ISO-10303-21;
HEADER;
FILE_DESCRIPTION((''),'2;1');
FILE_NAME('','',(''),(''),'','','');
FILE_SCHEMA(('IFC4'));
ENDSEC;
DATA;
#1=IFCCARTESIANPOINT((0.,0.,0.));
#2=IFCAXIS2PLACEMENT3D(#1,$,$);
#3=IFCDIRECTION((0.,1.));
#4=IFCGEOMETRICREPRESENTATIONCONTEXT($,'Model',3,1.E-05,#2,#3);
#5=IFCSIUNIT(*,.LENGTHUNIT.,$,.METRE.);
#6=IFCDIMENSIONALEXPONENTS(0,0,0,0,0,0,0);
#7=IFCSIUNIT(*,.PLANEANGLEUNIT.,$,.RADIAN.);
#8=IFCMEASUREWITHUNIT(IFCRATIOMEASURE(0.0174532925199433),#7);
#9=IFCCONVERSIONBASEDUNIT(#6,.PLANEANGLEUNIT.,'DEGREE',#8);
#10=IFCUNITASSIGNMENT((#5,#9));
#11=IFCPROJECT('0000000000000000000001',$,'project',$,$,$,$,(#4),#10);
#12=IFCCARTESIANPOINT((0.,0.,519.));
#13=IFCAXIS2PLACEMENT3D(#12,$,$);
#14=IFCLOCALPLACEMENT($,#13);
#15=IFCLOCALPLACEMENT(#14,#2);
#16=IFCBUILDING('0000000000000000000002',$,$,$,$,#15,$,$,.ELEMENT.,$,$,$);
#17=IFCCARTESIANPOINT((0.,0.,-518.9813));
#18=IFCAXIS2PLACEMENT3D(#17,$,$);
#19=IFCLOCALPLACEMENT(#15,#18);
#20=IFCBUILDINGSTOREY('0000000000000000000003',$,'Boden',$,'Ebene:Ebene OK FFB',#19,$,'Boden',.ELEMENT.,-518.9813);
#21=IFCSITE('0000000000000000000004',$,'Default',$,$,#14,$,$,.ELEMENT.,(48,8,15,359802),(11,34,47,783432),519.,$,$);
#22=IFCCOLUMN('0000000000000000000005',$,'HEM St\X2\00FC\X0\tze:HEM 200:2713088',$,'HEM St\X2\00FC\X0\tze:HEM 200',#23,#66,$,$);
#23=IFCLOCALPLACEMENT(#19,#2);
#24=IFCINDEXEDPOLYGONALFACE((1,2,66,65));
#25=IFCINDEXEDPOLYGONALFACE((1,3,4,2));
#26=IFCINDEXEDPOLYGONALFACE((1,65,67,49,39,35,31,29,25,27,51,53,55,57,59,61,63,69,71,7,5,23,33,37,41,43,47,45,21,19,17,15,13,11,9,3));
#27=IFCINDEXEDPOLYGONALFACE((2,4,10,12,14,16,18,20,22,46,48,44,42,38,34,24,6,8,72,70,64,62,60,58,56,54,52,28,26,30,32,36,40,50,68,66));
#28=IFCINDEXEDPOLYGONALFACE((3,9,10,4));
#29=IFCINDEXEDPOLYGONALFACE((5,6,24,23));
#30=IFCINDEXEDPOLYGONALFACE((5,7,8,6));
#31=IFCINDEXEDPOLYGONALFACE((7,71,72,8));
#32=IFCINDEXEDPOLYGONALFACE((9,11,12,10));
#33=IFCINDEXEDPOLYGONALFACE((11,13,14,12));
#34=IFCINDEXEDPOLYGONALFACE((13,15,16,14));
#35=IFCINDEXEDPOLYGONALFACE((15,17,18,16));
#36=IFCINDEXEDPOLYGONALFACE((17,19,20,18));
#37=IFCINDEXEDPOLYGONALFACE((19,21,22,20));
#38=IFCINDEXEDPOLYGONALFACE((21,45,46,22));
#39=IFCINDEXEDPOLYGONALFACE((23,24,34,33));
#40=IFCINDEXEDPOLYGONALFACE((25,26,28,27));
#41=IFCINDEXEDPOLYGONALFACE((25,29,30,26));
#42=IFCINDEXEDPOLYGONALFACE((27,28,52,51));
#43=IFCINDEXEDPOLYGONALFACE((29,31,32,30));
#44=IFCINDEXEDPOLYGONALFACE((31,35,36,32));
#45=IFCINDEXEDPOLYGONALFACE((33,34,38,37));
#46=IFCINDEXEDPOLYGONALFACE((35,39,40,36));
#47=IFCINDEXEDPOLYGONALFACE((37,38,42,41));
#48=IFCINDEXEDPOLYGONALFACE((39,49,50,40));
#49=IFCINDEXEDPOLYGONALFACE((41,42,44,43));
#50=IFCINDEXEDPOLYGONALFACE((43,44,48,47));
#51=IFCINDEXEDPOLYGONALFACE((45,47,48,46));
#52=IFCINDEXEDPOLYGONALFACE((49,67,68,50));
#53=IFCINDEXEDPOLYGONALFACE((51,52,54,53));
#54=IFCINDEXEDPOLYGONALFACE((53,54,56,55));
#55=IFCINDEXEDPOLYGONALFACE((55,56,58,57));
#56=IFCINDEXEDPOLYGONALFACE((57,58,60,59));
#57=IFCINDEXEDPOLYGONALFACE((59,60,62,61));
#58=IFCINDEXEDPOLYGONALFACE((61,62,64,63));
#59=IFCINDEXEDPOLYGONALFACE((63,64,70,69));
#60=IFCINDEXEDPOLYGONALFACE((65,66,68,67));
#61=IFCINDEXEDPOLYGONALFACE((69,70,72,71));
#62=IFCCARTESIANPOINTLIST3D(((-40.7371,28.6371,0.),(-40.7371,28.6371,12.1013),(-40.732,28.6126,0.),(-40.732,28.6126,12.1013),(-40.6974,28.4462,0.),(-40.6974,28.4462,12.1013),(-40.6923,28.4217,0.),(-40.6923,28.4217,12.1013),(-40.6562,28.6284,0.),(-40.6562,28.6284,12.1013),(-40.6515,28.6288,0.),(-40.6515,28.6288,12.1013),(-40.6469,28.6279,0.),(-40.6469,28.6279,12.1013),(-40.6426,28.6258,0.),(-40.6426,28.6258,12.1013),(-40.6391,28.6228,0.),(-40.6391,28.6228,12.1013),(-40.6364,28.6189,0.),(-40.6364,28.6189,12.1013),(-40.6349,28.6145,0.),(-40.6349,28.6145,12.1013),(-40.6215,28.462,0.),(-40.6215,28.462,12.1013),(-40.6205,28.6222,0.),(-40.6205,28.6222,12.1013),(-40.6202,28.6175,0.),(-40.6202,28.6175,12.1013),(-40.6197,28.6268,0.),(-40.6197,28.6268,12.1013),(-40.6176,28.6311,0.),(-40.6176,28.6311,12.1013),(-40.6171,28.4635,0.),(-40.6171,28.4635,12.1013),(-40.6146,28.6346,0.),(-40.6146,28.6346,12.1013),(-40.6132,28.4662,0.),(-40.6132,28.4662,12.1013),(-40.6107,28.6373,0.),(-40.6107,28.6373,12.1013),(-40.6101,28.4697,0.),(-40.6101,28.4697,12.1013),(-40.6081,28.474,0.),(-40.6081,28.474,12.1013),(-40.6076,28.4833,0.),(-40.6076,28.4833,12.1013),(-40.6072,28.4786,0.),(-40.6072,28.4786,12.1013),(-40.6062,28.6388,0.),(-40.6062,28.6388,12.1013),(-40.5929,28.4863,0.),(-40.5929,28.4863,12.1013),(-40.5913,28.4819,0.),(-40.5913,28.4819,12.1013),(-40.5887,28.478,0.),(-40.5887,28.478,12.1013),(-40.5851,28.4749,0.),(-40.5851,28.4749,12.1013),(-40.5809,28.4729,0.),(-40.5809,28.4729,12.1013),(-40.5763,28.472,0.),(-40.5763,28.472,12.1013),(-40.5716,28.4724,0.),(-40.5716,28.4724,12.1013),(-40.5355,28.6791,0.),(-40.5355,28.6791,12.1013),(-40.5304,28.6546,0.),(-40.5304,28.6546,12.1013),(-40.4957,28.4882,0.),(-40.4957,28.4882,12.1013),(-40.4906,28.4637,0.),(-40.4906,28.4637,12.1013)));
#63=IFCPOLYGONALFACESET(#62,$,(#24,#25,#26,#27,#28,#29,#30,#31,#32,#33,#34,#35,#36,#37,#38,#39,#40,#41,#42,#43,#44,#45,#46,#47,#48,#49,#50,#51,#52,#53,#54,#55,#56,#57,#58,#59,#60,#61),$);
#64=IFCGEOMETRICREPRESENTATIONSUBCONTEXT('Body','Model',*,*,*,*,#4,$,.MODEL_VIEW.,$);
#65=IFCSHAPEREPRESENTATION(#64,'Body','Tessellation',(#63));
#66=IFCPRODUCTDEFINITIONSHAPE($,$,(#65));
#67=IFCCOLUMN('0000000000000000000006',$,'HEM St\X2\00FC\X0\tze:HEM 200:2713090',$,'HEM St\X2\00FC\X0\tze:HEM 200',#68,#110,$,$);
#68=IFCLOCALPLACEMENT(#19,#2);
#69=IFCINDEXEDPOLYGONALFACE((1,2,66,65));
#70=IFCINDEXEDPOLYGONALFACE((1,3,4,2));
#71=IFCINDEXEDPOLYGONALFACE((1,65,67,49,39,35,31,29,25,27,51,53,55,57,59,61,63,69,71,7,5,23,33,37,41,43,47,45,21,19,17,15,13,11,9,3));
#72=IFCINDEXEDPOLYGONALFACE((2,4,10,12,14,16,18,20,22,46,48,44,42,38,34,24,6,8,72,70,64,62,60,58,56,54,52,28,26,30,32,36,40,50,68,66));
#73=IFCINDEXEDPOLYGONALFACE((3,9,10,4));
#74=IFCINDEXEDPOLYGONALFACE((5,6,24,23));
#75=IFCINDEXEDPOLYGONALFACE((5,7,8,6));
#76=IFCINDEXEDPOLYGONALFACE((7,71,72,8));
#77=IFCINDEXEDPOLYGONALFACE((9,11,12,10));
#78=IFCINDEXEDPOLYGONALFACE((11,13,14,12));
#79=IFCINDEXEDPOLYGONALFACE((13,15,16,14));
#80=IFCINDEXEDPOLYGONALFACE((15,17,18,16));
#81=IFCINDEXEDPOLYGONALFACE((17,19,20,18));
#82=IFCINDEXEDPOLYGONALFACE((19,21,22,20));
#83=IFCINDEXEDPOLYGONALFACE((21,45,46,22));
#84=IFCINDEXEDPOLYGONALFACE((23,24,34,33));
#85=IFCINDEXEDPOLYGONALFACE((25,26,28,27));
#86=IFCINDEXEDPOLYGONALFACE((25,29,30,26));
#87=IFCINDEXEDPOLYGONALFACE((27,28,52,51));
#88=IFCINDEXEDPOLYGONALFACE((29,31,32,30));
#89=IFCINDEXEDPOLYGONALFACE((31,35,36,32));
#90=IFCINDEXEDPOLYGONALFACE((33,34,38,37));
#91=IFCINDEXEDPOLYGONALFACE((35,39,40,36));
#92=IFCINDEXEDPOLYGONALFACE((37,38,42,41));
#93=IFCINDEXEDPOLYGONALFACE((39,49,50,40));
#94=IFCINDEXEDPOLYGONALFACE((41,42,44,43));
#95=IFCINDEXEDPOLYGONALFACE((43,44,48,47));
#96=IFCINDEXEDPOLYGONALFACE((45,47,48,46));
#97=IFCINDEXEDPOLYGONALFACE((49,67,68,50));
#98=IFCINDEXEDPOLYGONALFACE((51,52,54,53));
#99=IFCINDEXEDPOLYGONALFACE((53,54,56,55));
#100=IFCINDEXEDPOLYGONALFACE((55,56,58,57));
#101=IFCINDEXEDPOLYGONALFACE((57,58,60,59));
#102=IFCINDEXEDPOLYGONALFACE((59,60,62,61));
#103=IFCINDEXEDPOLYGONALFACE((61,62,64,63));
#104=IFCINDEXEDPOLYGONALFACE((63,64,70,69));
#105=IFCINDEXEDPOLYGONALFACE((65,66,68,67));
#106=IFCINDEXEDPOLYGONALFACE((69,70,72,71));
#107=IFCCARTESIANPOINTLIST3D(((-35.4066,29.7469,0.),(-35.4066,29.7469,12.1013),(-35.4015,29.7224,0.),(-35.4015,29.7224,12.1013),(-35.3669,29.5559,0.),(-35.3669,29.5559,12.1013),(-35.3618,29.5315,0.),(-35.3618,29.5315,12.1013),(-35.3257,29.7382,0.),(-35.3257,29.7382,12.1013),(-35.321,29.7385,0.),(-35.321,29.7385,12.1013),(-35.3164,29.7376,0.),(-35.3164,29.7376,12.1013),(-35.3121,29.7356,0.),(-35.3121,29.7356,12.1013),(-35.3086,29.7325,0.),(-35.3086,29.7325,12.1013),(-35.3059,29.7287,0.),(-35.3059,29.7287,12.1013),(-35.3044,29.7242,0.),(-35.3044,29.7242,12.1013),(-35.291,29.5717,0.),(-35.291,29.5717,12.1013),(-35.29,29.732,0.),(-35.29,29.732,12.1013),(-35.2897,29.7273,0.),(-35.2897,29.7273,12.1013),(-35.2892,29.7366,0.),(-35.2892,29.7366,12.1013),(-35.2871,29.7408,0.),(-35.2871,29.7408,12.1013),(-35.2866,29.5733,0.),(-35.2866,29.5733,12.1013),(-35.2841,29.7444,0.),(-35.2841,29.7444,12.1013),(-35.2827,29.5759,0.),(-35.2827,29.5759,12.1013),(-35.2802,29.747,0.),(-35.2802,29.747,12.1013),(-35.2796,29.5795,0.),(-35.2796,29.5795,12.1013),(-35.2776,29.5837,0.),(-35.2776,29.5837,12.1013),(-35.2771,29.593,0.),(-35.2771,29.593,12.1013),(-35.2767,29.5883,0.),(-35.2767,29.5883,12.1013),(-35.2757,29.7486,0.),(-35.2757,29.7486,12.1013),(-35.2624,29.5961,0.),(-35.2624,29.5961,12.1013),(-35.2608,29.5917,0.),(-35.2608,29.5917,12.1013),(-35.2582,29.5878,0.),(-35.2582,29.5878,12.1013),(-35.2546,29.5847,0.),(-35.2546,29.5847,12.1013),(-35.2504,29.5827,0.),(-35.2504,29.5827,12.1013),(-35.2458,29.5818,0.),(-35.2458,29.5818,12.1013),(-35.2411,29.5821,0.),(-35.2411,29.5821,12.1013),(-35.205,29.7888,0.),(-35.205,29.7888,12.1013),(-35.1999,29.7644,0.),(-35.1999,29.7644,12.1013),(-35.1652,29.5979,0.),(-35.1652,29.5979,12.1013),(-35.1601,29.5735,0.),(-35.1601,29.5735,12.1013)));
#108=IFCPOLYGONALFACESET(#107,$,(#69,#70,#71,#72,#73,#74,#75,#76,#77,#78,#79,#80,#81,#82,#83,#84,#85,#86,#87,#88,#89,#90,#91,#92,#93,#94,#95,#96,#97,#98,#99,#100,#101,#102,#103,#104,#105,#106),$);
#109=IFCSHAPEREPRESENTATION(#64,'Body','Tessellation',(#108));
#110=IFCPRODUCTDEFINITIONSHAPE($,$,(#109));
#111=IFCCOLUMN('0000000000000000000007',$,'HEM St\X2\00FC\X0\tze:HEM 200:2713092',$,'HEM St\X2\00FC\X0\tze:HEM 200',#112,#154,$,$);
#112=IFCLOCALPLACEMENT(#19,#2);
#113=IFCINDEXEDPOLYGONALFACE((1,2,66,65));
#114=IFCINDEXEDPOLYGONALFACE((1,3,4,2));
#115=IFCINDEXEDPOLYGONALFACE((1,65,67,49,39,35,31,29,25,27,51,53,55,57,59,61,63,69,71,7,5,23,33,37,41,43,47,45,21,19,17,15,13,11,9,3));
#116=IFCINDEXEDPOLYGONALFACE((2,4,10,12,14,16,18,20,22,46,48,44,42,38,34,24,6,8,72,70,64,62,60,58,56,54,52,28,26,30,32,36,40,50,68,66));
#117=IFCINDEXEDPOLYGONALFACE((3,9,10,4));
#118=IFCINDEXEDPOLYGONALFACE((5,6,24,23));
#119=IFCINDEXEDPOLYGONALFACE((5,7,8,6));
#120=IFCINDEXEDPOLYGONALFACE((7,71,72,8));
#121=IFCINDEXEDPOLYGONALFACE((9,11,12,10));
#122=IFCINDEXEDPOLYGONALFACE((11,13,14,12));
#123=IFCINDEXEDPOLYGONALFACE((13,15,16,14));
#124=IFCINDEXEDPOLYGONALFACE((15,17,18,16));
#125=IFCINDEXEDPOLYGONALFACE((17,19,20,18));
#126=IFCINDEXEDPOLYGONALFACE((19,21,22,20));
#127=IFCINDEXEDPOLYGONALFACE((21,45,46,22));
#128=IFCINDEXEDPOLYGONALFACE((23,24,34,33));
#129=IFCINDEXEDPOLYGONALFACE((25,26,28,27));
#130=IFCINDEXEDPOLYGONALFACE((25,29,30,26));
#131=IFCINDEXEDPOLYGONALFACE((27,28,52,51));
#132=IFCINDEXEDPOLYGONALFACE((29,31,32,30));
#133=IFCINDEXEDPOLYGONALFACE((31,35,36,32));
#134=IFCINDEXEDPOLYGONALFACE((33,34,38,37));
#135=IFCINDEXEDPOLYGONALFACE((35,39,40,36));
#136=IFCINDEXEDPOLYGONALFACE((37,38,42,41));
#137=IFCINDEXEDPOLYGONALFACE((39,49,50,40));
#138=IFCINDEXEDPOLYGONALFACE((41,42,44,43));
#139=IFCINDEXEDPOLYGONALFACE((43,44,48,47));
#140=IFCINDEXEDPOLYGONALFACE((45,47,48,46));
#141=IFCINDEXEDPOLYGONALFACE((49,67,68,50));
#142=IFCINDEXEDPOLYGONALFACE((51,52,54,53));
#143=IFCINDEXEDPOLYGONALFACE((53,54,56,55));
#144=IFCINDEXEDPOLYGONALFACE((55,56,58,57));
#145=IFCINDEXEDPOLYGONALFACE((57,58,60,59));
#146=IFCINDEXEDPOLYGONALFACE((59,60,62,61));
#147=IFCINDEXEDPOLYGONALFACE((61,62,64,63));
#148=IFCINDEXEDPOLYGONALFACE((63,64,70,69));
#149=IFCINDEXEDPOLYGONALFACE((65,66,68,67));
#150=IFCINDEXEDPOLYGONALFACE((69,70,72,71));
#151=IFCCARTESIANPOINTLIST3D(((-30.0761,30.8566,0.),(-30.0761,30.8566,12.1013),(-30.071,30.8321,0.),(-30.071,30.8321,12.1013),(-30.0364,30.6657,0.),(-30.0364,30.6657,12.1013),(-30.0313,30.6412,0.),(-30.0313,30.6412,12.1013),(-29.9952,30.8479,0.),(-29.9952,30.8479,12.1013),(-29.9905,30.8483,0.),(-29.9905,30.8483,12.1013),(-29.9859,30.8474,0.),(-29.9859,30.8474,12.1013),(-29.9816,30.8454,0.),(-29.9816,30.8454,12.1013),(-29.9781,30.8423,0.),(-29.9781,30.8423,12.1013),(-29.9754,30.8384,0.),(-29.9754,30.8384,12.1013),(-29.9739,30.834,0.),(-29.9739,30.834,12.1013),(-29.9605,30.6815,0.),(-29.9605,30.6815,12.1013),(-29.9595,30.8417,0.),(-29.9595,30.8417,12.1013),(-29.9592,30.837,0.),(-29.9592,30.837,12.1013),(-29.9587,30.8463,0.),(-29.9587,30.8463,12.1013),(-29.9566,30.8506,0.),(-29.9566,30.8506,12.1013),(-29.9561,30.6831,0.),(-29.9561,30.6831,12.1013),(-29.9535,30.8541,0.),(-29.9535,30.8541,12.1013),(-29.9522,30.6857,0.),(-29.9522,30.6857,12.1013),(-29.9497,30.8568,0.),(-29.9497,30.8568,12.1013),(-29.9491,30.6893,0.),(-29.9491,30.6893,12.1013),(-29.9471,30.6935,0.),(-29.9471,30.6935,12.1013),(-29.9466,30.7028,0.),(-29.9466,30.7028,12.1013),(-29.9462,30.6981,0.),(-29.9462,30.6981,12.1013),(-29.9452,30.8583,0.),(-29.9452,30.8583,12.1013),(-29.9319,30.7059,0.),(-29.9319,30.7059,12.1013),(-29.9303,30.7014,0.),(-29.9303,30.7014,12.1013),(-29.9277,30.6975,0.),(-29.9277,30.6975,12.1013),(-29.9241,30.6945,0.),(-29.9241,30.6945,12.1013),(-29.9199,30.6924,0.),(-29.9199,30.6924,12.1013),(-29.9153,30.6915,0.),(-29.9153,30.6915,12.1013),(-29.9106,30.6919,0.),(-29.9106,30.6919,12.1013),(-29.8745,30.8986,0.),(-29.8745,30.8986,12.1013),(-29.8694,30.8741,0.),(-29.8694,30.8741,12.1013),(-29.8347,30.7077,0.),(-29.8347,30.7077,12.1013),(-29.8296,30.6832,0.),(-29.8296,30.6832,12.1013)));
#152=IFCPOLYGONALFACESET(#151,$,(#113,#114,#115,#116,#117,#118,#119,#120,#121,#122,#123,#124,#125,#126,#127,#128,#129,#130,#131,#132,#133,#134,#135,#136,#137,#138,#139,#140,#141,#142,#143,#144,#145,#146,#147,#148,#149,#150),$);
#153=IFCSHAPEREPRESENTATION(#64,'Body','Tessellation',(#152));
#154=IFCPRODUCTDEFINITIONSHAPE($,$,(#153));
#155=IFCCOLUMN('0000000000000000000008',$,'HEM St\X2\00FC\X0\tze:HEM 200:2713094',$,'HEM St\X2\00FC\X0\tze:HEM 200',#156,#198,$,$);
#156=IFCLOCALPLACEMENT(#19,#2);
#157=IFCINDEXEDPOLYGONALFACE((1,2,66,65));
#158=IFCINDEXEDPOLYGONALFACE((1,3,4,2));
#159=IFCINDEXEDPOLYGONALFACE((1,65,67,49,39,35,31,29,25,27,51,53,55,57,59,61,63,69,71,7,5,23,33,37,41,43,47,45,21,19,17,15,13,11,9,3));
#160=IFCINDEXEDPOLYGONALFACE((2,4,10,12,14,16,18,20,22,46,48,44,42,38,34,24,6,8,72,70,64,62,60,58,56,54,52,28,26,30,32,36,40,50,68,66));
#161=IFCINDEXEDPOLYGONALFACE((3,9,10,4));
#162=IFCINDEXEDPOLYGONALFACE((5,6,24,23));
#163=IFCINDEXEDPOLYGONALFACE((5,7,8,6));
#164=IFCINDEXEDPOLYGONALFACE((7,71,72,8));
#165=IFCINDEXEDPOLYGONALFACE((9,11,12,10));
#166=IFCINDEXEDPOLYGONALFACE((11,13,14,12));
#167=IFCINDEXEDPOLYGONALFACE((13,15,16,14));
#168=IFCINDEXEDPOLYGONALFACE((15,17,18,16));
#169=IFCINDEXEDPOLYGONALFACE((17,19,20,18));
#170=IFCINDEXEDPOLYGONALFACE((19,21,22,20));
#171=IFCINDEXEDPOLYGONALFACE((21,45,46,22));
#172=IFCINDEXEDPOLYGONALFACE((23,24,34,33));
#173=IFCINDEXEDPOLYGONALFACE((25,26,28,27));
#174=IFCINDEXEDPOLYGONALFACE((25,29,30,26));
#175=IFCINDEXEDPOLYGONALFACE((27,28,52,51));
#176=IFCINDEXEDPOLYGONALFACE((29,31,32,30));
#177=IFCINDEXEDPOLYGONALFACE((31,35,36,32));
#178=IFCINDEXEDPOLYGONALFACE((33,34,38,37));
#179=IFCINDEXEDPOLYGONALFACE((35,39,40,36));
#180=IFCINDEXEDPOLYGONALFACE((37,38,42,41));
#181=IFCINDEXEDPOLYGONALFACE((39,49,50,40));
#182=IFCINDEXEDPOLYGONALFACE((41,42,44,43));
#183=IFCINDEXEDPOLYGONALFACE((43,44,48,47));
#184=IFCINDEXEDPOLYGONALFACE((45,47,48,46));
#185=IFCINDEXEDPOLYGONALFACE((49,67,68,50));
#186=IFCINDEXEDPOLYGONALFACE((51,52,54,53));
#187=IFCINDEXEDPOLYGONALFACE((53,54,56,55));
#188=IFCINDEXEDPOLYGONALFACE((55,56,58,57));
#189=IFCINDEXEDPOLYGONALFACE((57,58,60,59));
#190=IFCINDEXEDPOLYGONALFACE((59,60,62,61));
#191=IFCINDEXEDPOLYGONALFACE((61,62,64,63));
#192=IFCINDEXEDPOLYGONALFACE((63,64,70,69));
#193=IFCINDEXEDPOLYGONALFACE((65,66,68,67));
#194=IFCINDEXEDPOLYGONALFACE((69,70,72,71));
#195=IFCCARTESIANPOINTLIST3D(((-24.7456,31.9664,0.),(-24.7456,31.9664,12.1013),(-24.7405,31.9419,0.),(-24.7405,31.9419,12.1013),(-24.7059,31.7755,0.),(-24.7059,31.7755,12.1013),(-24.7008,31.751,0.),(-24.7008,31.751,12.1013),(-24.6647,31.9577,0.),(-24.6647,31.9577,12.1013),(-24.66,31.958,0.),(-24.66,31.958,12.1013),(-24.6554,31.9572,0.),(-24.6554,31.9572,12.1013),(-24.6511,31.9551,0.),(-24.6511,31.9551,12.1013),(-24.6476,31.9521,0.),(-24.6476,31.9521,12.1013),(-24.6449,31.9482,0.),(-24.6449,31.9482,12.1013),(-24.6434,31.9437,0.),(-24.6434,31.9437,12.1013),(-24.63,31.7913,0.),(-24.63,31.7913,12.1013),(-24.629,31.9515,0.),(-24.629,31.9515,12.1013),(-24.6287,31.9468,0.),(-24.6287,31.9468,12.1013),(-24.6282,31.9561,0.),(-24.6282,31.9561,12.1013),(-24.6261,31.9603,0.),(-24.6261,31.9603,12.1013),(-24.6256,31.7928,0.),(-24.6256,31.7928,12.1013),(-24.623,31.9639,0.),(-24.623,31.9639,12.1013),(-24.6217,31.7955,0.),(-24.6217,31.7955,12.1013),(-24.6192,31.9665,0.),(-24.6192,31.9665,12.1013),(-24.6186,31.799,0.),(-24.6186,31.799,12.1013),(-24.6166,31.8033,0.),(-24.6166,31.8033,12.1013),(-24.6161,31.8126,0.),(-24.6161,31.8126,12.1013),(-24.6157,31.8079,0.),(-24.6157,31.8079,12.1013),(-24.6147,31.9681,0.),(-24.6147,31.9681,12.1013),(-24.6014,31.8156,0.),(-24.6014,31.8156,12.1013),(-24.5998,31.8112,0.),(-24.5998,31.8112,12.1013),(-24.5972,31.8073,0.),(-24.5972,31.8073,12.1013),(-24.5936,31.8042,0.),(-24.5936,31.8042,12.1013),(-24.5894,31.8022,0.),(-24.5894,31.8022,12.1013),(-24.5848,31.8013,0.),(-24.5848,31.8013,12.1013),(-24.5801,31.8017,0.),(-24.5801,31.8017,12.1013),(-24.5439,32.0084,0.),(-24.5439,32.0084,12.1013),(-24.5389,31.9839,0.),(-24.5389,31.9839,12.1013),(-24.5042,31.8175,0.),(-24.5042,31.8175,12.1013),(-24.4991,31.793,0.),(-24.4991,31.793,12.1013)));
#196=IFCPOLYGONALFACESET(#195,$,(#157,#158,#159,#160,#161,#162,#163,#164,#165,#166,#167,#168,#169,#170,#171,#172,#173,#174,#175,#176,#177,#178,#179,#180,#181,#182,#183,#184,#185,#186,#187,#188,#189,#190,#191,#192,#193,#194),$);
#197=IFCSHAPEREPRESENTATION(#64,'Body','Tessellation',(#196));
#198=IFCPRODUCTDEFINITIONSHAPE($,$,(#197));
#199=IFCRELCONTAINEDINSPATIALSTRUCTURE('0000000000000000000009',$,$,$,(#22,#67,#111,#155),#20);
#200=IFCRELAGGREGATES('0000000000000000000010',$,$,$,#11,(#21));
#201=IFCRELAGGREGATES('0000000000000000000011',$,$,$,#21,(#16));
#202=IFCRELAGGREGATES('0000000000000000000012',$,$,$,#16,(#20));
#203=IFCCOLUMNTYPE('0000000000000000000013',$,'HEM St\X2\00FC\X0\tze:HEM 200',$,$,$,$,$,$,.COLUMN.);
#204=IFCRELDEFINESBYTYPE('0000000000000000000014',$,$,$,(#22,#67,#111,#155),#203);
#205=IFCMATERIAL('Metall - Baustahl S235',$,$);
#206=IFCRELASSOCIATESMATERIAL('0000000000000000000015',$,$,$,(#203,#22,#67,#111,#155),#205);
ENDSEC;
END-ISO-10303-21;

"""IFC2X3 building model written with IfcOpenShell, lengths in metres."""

from ifc_helpers import new_model, entity, si_unit, converted_unit, direction, frame, frame_2d, origin, place, context, subcontext, project, spatial, polyline, circle_curve, parameter, trimmed, segment, composite_curve, outline, extrude, source, transform, mapped, material, type_object, type_shapes, element, save


model = new_model("IFC2X3")

# Units and contexts
model_context = context("Model", 3, precision=1e-05, world=origin(), true_north=direction((0.0, 1.0)))
body_context = subcontext(model_context, "Body", "Model", "MODEL_VIEW")
ifc_project = project(units=[si_unit("LENGTHUNIT", "METRE"), converted_unit("PLANEANGLEUNIT", "DEGREE", entity("IfcRatioMeasure", 0.0174532925199433), si_unit("PLANEANGLEUNIT", "RADIAN"), dimensions=[0, 0, 0, 0, 0, 0, 0])], contexts=[model_context])

# Site, building, storey
site_placement = place(None, frame((0.0, 0.0, 519.0)))
site = spatial("IfcSite", under=ifc_project, at=site_placement, Name="Default", CompositionType="ELEMENT", RefLatitude=(48, 8, 15, 359802), RefLongitude=(11, 34, 47, 783432), RefElevation=519.0)
building_placement = place(site_placement, origin())
building = spatial("IfcBuilding", under=site, at=building_placement, CompositionType="ELEMENT")
storey_placement = place(building_placement, frame((0.0, 0.0, -518.9813)))
storey = spatial("IfcBuildingStorey", under=building, at=storey_placement, Name="Boden", ObjectType="Ebene:Ebene OK FFB", LongName="Boden", CompositionType="ELEMENT", Elevation=-518.9813)

# Columns
ifc_material = material(Name="Metall - Baustahl S235")
column_type_1 = type_object("IfcColumnType", Name="HEM Stütze:HEM 200", PredefinedType="COLUMN", material=ifc_material)
shared_shape_1 = source(origin(), body_context, "Body", "SweptSolid", [
    extrude(outline(composite_curve([segment(polyline([(0.085, -0.103), (0.11, -0.103)]), True, "CONTINUOUS"), segment(polyline([(0.11, -0.103), (0.11, 0.103)]), True, "CONTINUOUS"), segment(polyline([(0.11, 0.103), (0.085, 0.103)]), True, "CONTINUOUS"), segment(polyline([(0.085, 0.103), (0.085, 0.0255)]), True, "CONTINUOUS"), segment(trimmed(circle_curve(frame_2d((0.067, 0.0255), x_axis=(1.0, 0.0)), 0.018), [parameter(270.0)], [parameter(0.0)], True, "PARAMETER"), False, "CONTINUOUS"), segment(polyline([(0.067, 0.0075), (-0.067, 0.0075)]), True, "CONTINUOUS"), segment(trimmed(circle_curve(frame_2d((-0.067, 0.0255), x_axis=(0.0, -1.0)), 0.018), [parameter(270.0)], [parameter(0.0)], True, "PARAMETER"), False, "CONTINUOUS"), segment(polyline([(-0.085, 0.0255), (-0.085, 0.103)]), True, "CONTINUOUS"), segment(polyline([(-0.085, 0.103), (-0.11, 0.103)]), True, "CONTINUOUS"), segment(polyline([(-0.11, 0.103), (-0.11, -0.103)]), True, "CONTINUOUS"), segment(polyline([(-0.11, -0.103), (-0.085, -0.103)]), True, "CONTINUOUS"), segment(polyline([(-0.085, -0.103), (-0.085, -0.0255)]), True, "CONTINUOUS"), segment(trimmed(circle_curve(frame_2d((-0.067, -0.0255), x_axis=(-1.0, 0.0)), 0.018), [parameter(270.0)], [parameter(0.0)], True, "PARAMETER"), False, "CONTINUOUS"), segment(polyline([(-0.067, -0.0075), (0.067, -0.0075)]), True, "CONTINUOUS"), segment(trimmed(circle_curve(frame_2d((0.067, -0.0255), x_axis=(0.0, 1.0)), 0.018), [parameter(270.0)], [parameter(0.0)], True, "PARAMETER"), False, "CONTINUOUS"), segment(polyline([(0.085, -0.0255), (0.085, -0.103)]), True, "CONTINUOUS")], self_intersect=False)), frame((0.0, 0.0, -518.9813), z_axis=(0.0, 0.0, 1.0), x_axis=(0.0, -1.0, 0.0)), (0.0, 0.0, 1.0), 12.1013),
])
type_shapes(column_type_1, [shared_shape_1])
for number, where, z_axis, x_axis, name in (
    (1, (-40.6139, 28.5504, 518.9813), (0.0, 0.0, 1.0), (0.979008, 0.20382, 0.0), "HEM Stütze:HEM 200:2713088"),
    (2, (-35.2834, 29.6602, 518.9813), (0.0, 0.0, 1.0), (0.979008, 0.20382, 0.0), "HEM Stütze:HEM 200:2713090"),
    (3, (-29.9529, 30.7699, 518.9813), (0.0, 0.0, 1.0), (0.979008, 0.20382, 0.0), "HEM Stütze:HEM 200:2713092"),
    (4, (-24.6224, 31.8797, 518.9813), (0.0, 0.0, 1.0), (0.979008, 0.20382, 0.0), "HEM Stütze:HEM 200:2713094"),
):
    element("IfcColumn", number, at=place(storey_placement, frame(where, z_axis=z_axis, x_axis=x_axis)), inside=storey, type_object=column_type_1, material=ifc_material, Name=name, ObjectType="HEM Stütze:HEM 200", context=body_context, shape_type="MappedRepresentation", body=[
        mapped(shared_shape_1, transform((0.0, 0.0, 0.0), scale=1.0)),
    ])

save(model, "model.ifc")
